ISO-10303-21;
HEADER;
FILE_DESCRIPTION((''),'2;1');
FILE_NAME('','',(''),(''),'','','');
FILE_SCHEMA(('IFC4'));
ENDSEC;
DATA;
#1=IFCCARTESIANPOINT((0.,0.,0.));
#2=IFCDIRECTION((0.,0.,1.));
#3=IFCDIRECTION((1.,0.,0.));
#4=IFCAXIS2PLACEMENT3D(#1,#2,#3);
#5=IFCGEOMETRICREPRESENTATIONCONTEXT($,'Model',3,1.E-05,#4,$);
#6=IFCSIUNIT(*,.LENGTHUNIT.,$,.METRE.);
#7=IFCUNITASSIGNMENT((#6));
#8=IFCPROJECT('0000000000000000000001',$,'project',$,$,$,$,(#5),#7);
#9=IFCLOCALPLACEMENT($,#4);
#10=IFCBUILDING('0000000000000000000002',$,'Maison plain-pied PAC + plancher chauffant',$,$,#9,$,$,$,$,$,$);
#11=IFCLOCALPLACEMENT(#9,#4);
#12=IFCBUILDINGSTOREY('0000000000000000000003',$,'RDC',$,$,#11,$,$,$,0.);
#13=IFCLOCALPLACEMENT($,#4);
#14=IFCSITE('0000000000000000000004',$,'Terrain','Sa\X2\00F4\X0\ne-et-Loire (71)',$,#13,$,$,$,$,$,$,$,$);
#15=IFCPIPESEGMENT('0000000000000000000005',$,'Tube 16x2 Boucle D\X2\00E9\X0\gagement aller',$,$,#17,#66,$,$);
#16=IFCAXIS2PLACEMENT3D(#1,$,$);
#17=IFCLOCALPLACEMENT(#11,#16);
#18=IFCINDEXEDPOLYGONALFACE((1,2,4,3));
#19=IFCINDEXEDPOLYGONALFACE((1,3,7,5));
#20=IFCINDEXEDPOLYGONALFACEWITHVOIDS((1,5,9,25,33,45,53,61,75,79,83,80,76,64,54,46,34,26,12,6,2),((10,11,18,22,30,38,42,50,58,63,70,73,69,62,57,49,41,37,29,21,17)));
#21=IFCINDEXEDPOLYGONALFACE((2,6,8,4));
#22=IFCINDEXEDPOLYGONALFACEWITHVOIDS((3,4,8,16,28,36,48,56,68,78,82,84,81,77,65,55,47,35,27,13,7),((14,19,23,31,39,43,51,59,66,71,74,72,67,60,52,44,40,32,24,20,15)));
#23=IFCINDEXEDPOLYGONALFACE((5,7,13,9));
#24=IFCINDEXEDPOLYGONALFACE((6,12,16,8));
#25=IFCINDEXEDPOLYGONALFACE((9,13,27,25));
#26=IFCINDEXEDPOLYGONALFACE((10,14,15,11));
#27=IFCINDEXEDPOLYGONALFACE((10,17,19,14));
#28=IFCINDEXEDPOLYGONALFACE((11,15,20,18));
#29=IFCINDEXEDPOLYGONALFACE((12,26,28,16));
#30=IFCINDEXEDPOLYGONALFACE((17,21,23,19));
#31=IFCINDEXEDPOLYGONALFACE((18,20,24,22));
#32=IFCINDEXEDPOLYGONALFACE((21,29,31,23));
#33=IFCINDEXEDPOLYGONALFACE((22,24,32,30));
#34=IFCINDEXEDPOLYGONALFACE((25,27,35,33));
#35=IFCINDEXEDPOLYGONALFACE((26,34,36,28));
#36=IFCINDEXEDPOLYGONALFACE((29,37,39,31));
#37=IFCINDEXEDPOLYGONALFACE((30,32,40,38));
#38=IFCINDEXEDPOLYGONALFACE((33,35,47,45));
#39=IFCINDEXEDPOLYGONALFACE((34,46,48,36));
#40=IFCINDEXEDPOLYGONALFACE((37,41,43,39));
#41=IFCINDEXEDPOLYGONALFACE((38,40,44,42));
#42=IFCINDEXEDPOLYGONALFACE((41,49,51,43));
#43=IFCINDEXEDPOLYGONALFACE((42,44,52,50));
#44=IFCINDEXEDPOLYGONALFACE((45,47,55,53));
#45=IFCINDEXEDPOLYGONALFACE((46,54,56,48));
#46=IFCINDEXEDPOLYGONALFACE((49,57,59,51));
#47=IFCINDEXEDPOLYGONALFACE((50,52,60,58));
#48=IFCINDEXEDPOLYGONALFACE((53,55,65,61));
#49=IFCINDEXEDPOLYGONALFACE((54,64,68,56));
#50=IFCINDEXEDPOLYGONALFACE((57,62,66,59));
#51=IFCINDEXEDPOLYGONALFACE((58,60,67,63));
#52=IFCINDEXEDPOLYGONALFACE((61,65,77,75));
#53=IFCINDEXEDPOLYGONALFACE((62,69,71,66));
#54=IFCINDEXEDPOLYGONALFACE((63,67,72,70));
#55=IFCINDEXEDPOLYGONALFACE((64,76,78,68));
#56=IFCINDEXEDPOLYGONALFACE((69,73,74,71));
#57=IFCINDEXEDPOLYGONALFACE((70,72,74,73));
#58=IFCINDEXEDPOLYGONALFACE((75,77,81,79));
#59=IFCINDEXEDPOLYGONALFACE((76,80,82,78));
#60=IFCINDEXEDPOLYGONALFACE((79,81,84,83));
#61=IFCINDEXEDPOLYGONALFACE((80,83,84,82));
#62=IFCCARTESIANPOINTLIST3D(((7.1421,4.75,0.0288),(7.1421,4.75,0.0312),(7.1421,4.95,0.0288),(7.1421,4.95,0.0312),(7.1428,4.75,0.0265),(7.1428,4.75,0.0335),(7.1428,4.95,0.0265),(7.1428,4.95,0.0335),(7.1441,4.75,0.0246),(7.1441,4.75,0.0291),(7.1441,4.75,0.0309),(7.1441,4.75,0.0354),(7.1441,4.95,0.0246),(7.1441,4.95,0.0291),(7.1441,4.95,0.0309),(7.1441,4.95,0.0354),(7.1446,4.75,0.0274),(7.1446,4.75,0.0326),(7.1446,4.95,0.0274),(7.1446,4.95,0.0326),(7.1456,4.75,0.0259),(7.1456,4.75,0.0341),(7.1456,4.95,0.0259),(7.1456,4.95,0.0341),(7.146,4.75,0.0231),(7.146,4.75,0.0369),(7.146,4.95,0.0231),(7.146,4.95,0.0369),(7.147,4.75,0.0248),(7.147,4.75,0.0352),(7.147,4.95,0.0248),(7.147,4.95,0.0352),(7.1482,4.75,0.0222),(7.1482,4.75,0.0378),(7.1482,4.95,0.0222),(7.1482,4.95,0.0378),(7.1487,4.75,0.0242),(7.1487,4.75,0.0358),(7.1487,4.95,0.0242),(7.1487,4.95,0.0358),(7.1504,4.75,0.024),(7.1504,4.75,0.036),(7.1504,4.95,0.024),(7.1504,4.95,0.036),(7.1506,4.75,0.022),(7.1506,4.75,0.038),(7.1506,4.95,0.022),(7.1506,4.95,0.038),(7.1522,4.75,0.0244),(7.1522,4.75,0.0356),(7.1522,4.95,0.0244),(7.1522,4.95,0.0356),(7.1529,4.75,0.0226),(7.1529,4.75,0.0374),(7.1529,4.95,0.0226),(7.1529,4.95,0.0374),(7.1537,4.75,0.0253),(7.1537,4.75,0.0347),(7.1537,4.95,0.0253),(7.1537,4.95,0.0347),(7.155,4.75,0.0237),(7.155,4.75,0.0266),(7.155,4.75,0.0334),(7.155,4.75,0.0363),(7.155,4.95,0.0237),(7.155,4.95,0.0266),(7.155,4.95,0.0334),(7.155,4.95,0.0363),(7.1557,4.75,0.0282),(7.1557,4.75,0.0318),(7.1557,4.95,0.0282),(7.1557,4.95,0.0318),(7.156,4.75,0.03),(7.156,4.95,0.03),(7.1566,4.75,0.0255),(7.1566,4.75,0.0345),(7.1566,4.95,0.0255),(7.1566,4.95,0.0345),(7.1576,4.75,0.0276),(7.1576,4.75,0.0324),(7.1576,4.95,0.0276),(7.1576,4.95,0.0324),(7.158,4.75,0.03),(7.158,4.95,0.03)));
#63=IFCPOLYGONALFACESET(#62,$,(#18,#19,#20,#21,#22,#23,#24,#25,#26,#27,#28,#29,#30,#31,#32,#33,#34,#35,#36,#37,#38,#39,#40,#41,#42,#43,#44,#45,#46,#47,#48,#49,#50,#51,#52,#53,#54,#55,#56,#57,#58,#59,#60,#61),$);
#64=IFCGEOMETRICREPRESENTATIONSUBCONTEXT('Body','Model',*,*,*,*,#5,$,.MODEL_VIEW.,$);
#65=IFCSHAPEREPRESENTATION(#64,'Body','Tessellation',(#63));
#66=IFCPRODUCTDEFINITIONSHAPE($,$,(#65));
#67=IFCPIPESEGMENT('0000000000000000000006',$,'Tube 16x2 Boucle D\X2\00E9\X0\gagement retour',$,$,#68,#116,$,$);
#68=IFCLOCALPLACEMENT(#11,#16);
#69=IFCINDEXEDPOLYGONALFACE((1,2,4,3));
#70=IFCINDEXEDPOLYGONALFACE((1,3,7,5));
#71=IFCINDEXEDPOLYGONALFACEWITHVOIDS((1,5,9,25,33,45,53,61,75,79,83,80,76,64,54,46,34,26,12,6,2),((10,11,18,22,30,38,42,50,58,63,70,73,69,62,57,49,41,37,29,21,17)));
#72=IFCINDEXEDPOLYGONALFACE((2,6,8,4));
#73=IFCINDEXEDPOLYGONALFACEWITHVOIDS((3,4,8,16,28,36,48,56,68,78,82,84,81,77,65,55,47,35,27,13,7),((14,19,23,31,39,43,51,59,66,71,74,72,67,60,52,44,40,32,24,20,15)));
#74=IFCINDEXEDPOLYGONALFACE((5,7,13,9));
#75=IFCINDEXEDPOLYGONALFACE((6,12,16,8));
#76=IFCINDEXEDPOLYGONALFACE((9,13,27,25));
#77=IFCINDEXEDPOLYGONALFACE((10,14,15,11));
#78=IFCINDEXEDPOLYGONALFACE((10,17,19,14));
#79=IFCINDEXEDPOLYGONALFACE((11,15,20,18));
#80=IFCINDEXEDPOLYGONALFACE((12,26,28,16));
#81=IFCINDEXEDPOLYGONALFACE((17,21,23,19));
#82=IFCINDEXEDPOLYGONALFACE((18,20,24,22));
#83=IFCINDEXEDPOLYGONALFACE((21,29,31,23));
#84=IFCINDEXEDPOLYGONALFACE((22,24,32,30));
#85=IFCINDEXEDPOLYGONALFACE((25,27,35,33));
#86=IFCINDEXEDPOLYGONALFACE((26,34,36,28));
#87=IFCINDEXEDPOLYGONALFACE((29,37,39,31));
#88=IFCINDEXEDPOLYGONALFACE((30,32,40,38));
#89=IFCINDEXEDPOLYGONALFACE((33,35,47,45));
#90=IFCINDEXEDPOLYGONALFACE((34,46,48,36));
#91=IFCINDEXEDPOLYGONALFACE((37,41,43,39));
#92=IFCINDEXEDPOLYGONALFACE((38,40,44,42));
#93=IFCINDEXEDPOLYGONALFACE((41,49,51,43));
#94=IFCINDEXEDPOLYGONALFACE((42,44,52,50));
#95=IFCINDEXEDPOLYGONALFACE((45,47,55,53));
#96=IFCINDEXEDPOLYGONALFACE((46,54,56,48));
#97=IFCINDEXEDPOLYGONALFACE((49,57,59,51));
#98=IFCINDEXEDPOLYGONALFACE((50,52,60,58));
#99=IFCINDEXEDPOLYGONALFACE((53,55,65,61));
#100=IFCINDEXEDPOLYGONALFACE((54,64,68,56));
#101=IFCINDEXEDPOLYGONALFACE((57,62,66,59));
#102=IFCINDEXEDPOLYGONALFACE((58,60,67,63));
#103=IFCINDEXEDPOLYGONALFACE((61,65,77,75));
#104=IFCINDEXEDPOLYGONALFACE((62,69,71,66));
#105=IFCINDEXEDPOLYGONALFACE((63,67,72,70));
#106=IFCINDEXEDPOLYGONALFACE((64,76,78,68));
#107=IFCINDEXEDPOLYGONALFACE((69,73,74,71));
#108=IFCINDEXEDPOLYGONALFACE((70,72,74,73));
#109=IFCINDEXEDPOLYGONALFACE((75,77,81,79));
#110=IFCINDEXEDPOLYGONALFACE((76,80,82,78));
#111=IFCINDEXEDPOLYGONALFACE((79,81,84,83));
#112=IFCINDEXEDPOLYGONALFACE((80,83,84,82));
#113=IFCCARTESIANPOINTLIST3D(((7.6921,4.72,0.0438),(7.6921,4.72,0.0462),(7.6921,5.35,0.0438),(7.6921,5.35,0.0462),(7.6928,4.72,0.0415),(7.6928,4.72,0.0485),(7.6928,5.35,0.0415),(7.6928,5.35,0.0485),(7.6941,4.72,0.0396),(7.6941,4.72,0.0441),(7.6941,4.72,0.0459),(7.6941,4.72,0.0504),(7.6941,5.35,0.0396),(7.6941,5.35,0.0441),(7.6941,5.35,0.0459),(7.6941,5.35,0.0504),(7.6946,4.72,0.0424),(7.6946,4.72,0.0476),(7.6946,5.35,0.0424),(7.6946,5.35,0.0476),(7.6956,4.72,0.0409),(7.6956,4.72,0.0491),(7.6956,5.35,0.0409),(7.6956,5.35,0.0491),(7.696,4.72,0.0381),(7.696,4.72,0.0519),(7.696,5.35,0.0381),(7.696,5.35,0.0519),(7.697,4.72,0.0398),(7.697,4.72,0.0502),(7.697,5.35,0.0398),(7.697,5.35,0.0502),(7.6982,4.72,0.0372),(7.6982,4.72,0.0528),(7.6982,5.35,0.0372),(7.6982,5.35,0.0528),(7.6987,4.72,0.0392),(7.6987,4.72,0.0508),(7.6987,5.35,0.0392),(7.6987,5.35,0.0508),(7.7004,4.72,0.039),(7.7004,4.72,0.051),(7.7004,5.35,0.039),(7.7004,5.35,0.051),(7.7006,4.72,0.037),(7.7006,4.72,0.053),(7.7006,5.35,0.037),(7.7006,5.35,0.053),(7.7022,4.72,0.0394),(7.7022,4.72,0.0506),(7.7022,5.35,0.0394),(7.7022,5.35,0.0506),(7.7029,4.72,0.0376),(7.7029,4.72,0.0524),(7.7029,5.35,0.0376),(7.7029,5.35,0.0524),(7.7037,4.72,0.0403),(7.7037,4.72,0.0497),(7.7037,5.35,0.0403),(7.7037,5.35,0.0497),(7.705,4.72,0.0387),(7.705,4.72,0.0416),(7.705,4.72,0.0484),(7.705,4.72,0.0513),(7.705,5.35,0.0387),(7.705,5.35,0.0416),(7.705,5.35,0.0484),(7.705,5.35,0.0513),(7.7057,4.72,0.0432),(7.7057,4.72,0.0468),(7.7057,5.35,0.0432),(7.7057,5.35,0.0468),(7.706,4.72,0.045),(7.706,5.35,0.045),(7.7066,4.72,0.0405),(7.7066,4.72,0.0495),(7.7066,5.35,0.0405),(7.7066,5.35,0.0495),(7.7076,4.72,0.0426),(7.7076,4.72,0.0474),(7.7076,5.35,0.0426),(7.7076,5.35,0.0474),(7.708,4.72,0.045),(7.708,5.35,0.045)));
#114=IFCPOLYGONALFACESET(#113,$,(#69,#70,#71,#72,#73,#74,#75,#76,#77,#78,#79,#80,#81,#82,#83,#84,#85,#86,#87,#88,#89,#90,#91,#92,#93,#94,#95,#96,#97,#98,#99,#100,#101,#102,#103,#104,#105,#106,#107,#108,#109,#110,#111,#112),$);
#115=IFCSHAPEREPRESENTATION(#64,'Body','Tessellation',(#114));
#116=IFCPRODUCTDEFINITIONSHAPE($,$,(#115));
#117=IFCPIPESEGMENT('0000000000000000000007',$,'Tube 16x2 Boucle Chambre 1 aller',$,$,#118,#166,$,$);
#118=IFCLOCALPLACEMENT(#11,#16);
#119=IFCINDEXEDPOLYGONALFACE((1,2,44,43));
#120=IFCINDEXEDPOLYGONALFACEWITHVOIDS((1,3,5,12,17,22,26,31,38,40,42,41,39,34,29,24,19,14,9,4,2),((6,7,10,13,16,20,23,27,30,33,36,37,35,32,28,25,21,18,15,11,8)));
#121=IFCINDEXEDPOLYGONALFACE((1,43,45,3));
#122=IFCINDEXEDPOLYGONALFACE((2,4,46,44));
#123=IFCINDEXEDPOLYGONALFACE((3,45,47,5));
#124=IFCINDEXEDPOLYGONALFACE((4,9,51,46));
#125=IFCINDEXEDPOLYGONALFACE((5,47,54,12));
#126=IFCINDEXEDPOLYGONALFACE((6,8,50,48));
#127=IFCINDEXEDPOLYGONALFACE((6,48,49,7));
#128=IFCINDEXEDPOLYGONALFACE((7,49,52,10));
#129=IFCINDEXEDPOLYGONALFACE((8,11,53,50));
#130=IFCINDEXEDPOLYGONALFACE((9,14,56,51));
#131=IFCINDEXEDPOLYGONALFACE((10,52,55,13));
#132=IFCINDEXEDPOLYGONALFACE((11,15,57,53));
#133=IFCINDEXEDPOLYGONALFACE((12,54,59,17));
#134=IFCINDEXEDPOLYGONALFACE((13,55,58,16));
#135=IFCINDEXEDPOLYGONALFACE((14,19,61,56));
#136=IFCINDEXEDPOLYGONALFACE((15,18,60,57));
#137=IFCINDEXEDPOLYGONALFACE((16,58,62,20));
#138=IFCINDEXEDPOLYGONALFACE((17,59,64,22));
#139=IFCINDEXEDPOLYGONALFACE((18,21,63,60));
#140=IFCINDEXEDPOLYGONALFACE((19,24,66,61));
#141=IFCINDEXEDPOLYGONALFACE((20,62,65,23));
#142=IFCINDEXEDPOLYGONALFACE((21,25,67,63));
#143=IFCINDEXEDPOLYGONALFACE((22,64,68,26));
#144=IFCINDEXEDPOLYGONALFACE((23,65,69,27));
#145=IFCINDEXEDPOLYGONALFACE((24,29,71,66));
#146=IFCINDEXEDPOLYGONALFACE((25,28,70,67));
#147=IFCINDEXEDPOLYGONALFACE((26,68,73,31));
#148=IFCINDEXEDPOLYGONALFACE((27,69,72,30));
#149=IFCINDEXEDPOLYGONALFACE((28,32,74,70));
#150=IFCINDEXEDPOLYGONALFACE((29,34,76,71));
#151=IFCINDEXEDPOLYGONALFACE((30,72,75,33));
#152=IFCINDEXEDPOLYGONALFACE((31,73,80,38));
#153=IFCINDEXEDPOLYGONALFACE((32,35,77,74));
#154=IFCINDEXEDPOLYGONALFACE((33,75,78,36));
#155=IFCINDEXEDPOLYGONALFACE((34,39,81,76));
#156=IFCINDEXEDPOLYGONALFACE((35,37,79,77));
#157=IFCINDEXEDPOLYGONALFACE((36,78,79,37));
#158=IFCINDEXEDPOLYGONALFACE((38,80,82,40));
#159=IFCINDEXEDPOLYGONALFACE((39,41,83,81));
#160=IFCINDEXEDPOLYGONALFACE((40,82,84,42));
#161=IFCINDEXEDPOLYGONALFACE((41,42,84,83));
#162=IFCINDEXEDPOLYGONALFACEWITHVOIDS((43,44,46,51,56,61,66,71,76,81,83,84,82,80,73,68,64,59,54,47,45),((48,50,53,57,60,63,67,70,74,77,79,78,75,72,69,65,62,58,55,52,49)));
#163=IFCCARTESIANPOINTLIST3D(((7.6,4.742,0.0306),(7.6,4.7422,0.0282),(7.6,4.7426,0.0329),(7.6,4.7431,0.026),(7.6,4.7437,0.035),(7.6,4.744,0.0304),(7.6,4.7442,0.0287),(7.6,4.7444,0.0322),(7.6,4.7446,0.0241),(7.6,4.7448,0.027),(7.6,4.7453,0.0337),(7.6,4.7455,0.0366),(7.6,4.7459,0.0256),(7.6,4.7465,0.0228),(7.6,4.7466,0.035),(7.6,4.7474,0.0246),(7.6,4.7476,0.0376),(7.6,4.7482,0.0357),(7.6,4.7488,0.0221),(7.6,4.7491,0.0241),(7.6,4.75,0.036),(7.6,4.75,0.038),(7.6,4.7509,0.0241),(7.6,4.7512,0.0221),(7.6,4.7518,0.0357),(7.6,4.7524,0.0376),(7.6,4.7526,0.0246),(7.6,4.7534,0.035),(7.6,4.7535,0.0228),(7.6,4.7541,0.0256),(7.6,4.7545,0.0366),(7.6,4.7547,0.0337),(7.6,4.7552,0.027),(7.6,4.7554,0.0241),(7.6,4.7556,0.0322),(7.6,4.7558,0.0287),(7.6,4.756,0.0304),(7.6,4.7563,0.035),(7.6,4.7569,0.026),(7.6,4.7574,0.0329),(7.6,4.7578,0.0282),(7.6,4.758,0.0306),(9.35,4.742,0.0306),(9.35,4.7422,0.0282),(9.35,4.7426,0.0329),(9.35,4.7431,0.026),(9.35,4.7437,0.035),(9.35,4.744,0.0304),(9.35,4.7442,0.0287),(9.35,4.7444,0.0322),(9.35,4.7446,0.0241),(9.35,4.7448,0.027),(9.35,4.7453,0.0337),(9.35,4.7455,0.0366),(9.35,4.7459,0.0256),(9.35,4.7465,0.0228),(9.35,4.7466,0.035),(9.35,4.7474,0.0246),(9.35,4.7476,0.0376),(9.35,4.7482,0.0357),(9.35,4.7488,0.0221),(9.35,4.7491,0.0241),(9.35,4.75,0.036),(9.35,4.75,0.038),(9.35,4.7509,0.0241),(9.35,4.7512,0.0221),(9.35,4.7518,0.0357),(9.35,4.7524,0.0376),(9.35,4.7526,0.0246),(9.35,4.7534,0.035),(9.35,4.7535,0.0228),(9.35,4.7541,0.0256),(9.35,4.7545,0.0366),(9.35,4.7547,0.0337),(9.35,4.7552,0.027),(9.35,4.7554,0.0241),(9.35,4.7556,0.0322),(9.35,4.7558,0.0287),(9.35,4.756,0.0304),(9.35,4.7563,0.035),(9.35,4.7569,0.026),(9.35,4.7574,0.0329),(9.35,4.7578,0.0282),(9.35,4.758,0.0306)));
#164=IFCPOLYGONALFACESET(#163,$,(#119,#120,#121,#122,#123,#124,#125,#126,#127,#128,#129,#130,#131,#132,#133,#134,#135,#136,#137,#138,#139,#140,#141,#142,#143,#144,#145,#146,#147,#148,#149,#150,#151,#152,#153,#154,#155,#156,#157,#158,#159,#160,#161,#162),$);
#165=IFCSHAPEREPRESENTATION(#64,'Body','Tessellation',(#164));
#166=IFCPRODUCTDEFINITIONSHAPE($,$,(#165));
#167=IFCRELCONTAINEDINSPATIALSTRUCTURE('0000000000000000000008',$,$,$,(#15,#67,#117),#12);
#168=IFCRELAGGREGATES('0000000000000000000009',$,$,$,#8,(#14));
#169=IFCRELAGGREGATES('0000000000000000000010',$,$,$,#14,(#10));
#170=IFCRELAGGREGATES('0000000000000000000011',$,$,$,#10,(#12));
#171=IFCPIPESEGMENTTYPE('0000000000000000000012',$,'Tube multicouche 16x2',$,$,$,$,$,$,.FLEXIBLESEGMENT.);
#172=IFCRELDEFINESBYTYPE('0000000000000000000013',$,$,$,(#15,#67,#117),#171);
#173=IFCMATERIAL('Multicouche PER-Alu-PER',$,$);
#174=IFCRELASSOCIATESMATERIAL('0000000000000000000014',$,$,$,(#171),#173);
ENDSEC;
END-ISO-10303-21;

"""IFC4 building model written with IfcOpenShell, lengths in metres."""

from ifc_helpers import new_model, si_unit, frame, origin_with_axes, place, context, subcontext, project, spatial, hollow_circle, extrude, material, type_object, element, save


model = new_model("IFC4")

# Units and contexts
model_context = context("Model", 3, precision=1e-05, world=origin_with_axes())
body_context = subcontext(model_context, "Body", "Model", "MODEL_VIEW")
ifc_project = project(units=[si_unit("LENGTHUNIT", "METRE")], contexts=[model_context])

# Site, building, storey
site_placement = place(None, origin_with_axes())
site = spatial("IfcSite", under=ifc_project, at=site_placement, Name="Terrain", Description="Saône-et-Loire (71)")
building_placement = place(None, origin_with_axes())
building = spatial("IfcBuilding", under=site, at=building_placement, Name="Maison plain-pied PAC + plancher chauffant")
storey_placement = place(building_placement, origin_with_axes())
storey = spatial("IfcBuildingStorey", under=building, at=storey_placement, Name="RDC", Elevation=0.0)

# Pipe segments
ifc_material = material(Name="Multicouche PER-Alu-PER")
pipe_segment_type = type_object("IfcPipeSegmentType", Name="Tube multicouche 16x2", PredefinedType="FLEXIBLESEGMENT", material=ifc_material)
pipe_segment_1_placement = place(storey_placement, frame((7.15, 4.75, 0.03), z_axis=(0.0, 1.0, 0.0), x_axis=(1.0, 0.0, 0.0)))
element("IfcPipeSegment", 1, at=pipe_segment_1_placement, inside=storey, type_object=pipe_segment_type, Name="Tube 16x2 Boucle Dégagement aller", context=body_context, shape_type="SweptSolid", body=[
    extrude(hollow_circle(Radius=0.008, WallThickness=0.002), origin_with_axes(), (0.0, 0.0, 1.0), 0.2),
])
pipe_segment_2_placement = place(storey_placement, frame((7.7, 4.72, 0.045), z_axis=(0.0, 1.0, 0.0), x_axis=(1.0, 0.0, 0.0)))
element("IfcPipeSegment", 2, at=pipe_segment_2_placement, inside=storey, type_object=pipe_segment_type, Name="Tube 16x2 Boucle Dégagement retour", context=body_context, shape_type="SweptSolid", body=[
    extrude(hollow_circle(Radius=0.008, WallThickness=0.002), origin_with_axes(), (0.0, 0.0, 1.0), 0.63),
])
pipe_segment_3_placement = place(storey_placement, frame((7.6, 4.75, 0.03), z_axis=(1.0, 0.0, 0.0), x_axis=(0.0, 0.0, 1.0)))
element("IfcPipeSegment", 3, at=pipe_segment_3_placement, inside=storey, type_object=pipe_segment_type, Name="Tube 16x2 Boucle Chambre 1 aller", context=body_context, shape_type="SweptSolid", body=[
    extrude(hollow_circle(Radius=0.008, WallThickness=0.002), origin_with_axes(), (0.0, 0.0, 1.0), 1.75),
])

save(model, "model.ifc")
